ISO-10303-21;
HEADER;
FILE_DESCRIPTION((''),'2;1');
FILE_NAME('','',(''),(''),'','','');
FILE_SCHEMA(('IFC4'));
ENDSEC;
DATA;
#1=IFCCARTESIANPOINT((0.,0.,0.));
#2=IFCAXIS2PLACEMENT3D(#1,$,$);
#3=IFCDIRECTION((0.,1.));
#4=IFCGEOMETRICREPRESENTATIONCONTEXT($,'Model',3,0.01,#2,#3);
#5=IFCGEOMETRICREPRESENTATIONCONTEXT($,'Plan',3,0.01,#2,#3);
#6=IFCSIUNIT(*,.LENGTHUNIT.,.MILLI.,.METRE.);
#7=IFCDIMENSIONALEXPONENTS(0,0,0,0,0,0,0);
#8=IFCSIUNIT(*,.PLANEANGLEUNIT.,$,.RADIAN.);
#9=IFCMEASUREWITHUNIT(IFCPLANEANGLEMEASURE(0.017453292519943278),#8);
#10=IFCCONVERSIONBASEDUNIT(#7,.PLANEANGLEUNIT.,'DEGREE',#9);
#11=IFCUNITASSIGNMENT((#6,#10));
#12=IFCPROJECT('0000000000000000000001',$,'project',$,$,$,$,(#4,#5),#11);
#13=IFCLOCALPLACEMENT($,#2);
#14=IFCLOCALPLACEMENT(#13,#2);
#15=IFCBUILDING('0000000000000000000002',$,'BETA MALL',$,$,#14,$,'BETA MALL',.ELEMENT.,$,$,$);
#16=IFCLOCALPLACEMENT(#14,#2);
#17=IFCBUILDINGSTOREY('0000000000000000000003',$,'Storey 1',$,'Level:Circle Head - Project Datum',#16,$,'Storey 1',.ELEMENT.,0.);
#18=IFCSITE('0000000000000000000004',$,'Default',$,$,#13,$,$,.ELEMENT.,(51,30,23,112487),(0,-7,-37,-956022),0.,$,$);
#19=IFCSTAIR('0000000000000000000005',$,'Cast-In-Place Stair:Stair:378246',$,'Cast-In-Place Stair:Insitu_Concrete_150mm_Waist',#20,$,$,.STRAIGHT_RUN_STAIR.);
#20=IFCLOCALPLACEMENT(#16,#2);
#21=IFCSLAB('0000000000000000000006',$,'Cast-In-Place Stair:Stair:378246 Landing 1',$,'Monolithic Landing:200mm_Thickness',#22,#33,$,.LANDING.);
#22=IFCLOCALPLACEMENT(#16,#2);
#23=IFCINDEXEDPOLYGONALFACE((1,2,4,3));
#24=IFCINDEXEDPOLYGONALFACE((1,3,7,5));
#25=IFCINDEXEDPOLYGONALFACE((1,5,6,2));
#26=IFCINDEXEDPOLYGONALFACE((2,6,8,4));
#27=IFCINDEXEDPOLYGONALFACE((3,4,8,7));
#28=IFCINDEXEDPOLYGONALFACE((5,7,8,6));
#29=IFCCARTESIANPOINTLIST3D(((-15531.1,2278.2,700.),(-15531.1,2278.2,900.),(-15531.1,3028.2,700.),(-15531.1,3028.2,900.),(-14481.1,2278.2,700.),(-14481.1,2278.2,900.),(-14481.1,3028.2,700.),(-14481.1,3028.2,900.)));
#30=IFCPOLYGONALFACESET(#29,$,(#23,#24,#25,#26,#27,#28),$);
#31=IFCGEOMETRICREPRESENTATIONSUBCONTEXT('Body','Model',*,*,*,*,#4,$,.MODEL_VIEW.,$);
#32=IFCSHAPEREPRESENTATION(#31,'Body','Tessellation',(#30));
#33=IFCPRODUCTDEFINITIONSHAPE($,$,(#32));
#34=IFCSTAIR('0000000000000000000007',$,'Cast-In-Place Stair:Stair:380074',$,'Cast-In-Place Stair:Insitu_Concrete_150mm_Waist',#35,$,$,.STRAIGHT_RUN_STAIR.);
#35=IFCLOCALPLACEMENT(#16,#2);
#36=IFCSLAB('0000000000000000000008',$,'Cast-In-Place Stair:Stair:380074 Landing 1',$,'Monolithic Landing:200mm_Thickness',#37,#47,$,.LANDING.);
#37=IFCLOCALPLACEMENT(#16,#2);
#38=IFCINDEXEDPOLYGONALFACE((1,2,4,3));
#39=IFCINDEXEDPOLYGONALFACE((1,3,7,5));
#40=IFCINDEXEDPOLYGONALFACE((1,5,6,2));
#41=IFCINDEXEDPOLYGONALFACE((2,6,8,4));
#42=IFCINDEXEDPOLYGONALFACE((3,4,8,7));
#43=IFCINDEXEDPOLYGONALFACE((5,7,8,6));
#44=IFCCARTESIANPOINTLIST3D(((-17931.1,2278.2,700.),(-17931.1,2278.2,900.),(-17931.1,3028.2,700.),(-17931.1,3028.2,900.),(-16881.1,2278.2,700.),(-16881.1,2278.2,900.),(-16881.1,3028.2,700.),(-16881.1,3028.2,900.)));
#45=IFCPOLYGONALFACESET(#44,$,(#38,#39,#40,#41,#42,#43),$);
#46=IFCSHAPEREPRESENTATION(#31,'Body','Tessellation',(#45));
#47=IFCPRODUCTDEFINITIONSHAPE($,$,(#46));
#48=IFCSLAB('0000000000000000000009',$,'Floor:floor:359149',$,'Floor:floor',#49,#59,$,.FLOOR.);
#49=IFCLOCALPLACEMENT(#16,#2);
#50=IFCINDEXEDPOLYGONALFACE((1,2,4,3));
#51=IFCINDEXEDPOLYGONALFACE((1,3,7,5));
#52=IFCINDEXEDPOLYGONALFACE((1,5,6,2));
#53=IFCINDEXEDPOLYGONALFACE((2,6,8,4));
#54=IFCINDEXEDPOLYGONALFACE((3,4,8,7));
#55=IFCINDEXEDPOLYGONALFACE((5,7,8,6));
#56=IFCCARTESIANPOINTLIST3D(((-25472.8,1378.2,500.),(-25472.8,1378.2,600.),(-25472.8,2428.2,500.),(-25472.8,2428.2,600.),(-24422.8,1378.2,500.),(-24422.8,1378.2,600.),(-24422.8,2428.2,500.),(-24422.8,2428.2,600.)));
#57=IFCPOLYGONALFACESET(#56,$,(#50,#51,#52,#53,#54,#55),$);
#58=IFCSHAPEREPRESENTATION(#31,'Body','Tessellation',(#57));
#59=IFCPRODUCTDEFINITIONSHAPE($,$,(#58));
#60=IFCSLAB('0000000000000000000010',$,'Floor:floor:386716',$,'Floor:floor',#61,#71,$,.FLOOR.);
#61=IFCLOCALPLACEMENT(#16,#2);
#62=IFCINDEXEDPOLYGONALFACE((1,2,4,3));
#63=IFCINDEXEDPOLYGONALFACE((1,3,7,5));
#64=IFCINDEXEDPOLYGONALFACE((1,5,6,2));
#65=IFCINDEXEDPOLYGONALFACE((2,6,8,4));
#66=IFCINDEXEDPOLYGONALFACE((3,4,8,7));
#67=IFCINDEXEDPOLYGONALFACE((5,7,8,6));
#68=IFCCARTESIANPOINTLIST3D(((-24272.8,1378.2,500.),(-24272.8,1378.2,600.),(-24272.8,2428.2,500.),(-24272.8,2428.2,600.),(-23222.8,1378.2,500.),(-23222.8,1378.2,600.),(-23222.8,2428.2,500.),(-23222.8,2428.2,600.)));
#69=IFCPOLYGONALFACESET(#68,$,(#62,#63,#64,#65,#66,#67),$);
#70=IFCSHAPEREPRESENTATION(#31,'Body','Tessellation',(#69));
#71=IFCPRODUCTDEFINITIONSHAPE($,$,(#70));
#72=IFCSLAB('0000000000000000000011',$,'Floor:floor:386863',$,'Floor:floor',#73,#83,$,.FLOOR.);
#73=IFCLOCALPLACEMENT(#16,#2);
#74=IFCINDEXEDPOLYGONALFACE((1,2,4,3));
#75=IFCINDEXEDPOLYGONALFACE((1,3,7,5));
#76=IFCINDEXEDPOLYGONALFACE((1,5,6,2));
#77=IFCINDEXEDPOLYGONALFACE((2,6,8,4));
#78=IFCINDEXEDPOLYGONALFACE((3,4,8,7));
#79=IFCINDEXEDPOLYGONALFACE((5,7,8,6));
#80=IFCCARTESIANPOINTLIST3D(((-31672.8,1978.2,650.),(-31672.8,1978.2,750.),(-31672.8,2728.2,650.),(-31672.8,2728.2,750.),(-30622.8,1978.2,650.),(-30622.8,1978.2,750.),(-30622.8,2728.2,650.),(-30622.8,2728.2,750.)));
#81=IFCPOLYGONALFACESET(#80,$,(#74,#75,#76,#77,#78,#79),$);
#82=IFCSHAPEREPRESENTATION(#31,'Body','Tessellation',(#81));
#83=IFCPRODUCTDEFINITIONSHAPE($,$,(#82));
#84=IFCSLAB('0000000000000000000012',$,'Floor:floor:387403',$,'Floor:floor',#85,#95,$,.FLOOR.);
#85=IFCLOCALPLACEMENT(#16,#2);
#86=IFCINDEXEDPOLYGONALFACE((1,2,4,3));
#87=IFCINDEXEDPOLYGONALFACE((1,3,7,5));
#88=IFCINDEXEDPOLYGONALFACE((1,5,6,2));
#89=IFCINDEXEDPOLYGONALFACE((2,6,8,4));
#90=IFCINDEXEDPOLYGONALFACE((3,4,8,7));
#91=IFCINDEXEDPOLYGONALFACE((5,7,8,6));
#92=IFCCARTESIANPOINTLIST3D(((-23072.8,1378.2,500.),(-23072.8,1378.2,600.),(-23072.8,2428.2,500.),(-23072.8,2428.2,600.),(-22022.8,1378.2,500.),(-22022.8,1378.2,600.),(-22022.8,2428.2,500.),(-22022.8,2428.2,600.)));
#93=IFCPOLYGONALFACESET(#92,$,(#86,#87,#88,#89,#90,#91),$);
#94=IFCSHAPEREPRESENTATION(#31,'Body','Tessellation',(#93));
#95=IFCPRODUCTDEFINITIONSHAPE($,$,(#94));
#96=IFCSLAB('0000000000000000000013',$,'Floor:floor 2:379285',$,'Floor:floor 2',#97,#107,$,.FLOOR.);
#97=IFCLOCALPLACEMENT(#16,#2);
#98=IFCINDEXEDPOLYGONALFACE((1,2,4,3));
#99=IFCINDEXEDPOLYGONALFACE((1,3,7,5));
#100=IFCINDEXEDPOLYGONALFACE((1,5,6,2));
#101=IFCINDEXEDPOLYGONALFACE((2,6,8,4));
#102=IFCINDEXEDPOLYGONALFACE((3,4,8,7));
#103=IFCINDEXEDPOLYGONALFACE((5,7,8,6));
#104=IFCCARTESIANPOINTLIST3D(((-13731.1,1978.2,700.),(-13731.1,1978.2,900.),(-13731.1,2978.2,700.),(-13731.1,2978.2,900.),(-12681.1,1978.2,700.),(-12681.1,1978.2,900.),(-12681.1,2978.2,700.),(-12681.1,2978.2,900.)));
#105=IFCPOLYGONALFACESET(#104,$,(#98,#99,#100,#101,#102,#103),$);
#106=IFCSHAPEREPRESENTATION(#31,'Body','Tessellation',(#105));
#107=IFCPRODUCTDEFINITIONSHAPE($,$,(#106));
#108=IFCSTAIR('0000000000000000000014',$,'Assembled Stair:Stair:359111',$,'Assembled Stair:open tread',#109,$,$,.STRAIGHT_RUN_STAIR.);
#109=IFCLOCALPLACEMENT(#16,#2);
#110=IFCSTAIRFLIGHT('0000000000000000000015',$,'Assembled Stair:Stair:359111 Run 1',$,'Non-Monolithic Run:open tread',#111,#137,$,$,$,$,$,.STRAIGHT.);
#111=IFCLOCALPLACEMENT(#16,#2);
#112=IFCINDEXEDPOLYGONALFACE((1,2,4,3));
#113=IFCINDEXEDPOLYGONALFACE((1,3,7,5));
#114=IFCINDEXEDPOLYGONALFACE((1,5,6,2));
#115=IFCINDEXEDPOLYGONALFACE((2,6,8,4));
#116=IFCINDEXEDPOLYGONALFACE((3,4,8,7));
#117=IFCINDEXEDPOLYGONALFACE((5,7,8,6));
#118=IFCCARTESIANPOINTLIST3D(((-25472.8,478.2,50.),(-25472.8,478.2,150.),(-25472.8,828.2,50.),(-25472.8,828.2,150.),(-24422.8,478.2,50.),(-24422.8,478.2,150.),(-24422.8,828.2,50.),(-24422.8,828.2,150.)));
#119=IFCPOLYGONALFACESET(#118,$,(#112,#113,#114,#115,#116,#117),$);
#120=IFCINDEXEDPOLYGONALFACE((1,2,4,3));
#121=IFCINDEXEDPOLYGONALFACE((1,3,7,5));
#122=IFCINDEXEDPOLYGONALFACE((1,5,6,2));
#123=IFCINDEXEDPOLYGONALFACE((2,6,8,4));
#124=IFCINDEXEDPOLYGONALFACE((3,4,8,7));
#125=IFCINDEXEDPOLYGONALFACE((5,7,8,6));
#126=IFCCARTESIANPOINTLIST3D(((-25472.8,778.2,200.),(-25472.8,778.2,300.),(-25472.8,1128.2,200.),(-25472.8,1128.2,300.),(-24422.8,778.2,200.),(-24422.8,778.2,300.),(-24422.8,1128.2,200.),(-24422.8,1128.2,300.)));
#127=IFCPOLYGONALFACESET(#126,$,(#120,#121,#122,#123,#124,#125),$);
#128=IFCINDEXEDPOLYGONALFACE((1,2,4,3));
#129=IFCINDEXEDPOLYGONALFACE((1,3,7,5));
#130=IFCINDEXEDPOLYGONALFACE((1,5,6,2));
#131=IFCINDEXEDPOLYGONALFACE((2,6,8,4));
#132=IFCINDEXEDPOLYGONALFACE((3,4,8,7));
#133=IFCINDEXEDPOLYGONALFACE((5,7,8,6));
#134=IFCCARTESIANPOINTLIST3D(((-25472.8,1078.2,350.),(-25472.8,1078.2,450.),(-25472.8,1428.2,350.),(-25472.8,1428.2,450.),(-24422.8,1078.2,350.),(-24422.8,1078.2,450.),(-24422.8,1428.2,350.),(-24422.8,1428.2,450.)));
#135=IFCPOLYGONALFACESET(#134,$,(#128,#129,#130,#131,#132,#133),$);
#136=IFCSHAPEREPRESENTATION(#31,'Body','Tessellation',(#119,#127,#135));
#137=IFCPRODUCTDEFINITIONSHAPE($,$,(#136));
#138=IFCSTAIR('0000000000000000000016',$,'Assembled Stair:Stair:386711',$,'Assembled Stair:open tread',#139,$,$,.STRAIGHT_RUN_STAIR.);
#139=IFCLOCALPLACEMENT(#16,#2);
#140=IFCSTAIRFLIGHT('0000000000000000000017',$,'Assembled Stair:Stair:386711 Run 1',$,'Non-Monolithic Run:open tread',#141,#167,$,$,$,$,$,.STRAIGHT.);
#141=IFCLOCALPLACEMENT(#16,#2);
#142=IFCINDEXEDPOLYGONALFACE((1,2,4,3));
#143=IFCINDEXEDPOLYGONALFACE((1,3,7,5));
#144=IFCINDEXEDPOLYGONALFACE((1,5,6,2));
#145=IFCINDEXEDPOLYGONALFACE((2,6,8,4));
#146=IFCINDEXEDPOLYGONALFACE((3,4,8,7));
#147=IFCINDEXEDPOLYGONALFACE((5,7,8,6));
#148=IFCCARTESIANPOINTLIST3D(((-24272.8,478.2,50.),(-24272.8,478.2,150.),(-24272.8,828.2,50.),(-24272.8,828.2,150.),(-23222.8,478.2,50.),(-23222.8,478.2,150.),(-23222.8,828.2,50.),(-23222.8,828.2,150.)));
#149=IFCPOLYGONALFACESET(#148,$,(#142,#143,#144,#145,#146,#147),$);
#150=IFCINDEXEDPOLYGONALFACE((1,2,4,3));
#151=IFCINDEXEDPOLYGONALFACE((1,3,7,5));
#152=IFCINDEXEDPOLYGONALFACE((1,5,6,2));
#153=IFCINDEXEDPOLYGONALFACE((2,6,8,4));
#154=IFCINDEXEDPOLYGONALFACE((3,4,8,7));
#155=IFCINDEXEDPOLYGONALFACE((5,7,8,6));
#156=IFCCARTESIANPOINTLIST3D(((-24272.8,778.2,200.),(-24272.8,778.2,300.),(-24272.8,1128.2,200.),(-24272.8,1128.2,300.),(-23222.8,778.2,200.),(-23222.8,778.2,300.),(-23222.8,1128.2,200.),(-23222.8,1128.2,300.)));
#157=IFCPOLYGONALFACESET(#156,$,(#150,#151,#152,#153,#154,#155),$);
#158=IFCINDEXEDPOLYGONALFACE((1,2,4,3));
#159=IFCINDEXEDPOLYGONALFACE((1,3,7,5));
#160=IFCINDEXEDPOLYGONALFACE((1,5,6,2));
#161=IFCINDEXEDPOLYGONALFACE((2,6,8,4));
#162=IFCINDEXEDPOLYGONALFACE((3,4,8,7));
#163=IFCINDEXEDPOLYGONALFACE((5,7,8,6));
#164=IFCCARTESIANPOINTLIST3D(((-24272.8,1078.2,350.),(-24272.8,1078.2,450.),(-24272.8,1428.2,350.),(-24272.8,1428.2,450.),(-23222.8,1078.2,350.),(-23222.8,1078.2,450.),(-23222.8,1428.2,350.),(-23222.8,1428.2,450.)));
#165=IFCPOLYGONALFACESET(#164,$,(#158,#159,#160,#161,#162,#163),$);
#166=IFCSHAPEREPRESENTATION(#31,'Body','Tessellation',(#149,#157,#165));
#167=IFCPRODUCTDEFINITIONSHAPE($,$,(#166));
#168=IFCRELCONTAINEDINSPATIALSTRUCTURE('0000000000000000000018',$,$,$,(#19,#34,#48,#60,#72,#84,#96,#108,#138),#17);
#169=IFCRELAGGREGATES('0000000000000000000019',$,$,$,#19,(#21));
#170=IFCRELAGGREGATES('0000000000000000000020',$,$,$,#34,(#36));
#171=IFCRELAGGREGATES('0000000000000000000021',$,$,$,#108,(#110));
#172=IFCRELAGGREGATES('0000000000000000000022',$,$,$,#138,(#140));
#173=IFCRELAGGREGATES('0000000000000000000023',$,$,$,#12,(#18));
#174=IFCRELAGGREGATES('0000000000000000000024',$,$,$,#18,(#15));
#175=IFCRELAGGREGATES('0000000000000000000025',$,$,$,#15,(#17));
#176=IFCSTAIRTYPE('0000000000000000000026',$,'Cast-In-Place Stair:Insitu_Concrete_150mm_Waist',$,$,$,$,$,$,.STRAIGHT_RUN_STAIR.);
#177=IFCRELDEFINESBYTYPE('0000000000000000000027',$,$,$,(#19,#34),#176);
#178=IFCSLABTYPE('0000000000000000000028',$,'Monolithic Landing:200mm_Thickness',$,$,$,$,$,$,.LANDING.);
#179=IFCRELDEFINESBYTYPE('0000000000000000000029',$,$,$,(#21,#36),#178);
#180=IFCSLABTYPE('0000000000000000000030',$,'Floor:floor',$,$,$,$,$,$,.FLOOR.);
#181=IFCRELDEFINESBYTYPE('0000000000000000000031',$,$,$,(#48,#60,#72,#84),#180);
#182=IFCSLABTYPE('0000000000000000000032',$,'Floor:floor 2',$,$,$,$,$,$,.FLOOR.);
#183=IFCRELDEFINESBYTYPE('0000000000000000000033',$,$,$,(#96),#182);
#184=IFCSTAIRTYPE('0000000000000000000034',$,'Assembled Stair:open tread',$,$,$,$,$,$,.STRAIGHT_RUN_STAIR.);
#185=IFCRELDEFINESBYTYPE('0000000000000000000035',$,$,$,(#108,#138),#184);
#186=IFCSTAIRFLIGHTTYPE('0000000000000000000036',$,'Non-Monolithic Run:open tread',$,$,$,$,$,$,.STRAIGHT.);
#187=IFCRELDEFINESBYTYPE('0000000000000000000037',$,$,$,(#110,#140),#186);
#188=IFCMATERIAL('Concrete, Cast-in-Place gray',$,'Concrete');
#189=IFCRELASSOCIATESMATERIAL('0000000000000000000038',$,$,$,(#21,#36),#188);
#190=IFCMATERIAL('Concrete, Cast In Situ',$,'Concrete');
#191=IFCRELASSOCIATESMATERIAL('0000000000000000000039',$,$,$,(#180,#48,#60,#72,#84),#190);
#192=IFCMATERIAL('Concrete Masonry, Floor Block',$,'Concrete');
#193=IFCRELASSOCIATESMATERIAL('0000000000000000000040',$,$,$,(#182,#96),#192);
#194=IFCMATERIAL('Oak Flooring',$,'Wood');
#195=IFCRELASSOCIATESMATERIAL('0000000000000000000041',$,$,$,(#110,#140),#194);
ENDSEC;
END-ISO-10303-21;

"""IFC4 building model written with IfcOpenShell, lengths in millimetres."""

from ifc_helpers import new_model, entity, si_unit, converted_unit, direction, frame, origin, place, context, subcontext, project, spatial, indexed_curve, outline, extrude, material, type_object, element, aggregate, save


model = new_model("IFC4")

# Units and contexts
model_context = context("Model", 3, precision=0.01, world=origin(), true_north=direction((0.0, 1.0)))
plan_context = context("Plan", 3, precision=0.01, world=origin(), true_north=direction((0.0, 1.0)))
body_context = subcontext(model_context, "Body", "Model", "MODEL_VIEW")
ifc_project = project(units=[si_unit("LENGTHUNIT", "METRE", prefix="MILLI"), converted_unit("PLANEANGLEUNIT", "DEGREE", entity("IfcPlaneAngleMeasure", 0.017453292519943278), si_unit("PLANEANGLEUNIT", "RADIAN"), dimensions=[0, 0, 0, 0, 0, 0, 0])], contexts=[model_context, plan_context])

# Site, building, storey
site_placement = place(None, origin())
site = spatial("IfcSite", under=ifc_project, at=site_placement, Name="Default", CompositionType="ELEMENT", RefLatitude=(51, 30, 23, 112487), RefLongitude=(0, -7, -37, -956022), RefElevation=0.0)
building_placement = place(site_placement, origin())
building = spatial("IfcBuilding", under=site, at=building_placement, Name="BETA MALL", LongName="BETA MALL", CompositionType="ELEMENT")
storey_placement = place(building_placement, origin())
storey = spatial("IfcBuildingStorey", under=building, at=storey_placement, Name="Storey 1", ObjectType="Level:Circle Head - Project Datum", LongName="Storey 1", CompositionType="ELEMENT", Elevation=0.0)

# Stairs, slabs
stair_type_1 = type_object("IfcStairType", Name="Cast-In-Place Stair:Insitu_Concrete_150mm_Waist", PredefinedType="STRAIGHT_RUN_STAIR")
ifc_material_1 = material(Name="Concrete, Cast-in-Place gray", Category="Concrete")
slab_type_1 = type_object("IfcSlabType", Name="Monolithic Landing:200mm_Thickness", PredefinedType="LANDING")
stair_1_placement = place(storey_placement, origin())
stair_1 = element("IfcStair", 1, at=stair_1_placement, inside=storey, type_object=stair_type_1, Name="Cast-In-Place Stair:Stair:378246", ObjectType="Cast-In-Place Stair:Insitu_Concrete_150mm_Waist", PredefinedType="STRAIGHT_RUN_STAIR")
slab_1_placement = place(stair_1_placement, origin())
slab_1 = element("IfcSlab", 2, at=slab_1_placement, type_object=slab_type_1, material=ifc_material_1, Name="Cast-In-Place Stair:Stair:378246 Landing 1", ObjectType="Monolithic Landing:200mm_Thickness", PredefinedType="LANDING", context=body_context, shape_type="SweptSolid", body=[
    extrude(outline(indexed_curve([(-375.0, -525.0), (375.0, -525.0), (375.0, 525.0), (-375.0, 525.0), (-375.0, -525.0)], self_intersect=False)), frame((-15006.1, 2653.2, 700.0), z_axis=(0.0, 0.0, 1.0), x_axis=(0.0, 1.0, 0.0)), (0.0, 0.0, 1.0), 200.0),
])
aggregate(stair_1, [slab_1])
stair_2_placement = place(storey_placement, origin())
stair_2 = element("IfcStair", 3, at=stair_2_placement, inside=storey, type_object=stair_type_1, Name="Cast-In-Place Stair:Stair:380074", ObjectType="Cast-In-Place Stair:Insitu_Concrete_150mm_Waist", PredefinedType="STRAIGHT_RUN_STAIR")
slab_2_placement = place(stair_2_placement, origin())
slab_2 = element("IfcSlab", 4, at=slab_2_placement, type_object=slab_type_1, material=ifc_material_1, Name="Cast-In-Place Stair:Stair:380074 Landing 1", ObjectType="Monolithic Landing:200mm_Thickness", PredefinedType="LANDING", context=body_context, shape_type="SweptSolid", body=[
    extrude(outline(indexed_curve([(-375.0, -525.0), (375.0, -525.0), (375.0, 525.0), (-375.0, 525.0), (-375.0, -525.0)], self_intersect=False)), frame((-17406.1, 2653.2, 700.0), z_axis=(0.0, 0.0, 1.0), x_axis=(0.0, 1.0, 0.0)), (0.0, 0.0, 1.0), 200.0),
])
aggregate(stair_2, [slab_2])

# Slabs
ifc_material_2 = material(Name="Concrete, Cast In Situ", Category="Concrete")
slab_type_2 = type_object("IfcSlabType", Name="Floor:floor", PredefinedType="FLOOR", material=ifc_material_2)
slab_3_placement = place(storey_placement, origin())
element("IfcSlab", 5, at=slab_3_placement, inside=storey, type_object=slab_type_2, material=ifc_material_2, Name="Floor:floor:359149", ObjectType="Floor:floor", PredefinedType="FLOOR", context=body_context, shape_type="SweptSolid", body=[
    extrude(outline(indexed_curve([(-525.0, -525.0), (525.0, -525.0), (525.0, 525.0), (-525.0, 525.0), (-525.0, -525.0)], self_intersect=False)), frame((-24947.8, 1903.2, 600.0), z_axis=(0.0, 0.0, -1.0), x_axis=(0.0, 1.0, 0.0)), (0.0, 0.0, 1.0), 100.0),
])
slab_4_placement = place(storey_placement, origin())
element("IfcSlab", 6, at=slab_4_placement, inside=storey, type_object=slab_type_2, material=ifc_material_2, Name="Floor:floor:386716", ObjectType="Floor:floor", PredefinedType="FLOOR", context=body_context, shape_type="SweptSolid", body=[
    extrude(outline(indexed_curve([(-525.0, -525.0), (525.0, -525.0), (525.0, 525.0), (-525.0, 525.0), (-525.0, -525.0)], self_intersect=False)), frame((-23747.8, 1903.2, 600.0), z_axis=(0.0, 0.0, -1.0), x_axis=(0.0, 1.0, 0.0)), (0.0, 0.0, 1.0), 100.0),
])
slab_5_placement = place(storey_placement, origin())
element("IfcSlab", 7, at=slab_5_placement, inside=storey, type_object=slab_type_2, material=ifc_material_2, Name="Floor:floor:386863", ObjectType="Floor:floor", PredefinedType="FLOOR", context=body_context, shape_type="SweptSolid", body=[
    extrude(outline(indexed_curve([(-375.0, -525.0), (375.0, -525.0), (375.0, 525.0), (-375.0, 525.0), (-375.0, -525.0)], self_intersect=False)), frame((-31147.8, 2353.2, 750.0), z_axis=(0.0, 0.0, -1.0), x_axis=(0.0, 1.0, 0.0)), (0.0, 0.0, 1.0), 100.0),
])
slab_6_placement = place(storey_placement, origin())
element("IfcSlab", 8, at=slab_6_placement, inside=storey, type_object=slab_type_2, material=ifc_material_2, Name="Floor:floor:387403", ObjectType="Floor:floor", PredefinedType="FLOOR", context=body_context, shape_type="SweptSolid", body=[
    extrude(outline(indexed_curve([(-525.0, -525.0), (525.0, -525.0), (525.0, 525.0), (-525.0, 525.0), (-525.0, -525.0)], self_intersect=False)), frame((-22547.8, 1903.2, 600.0), z_axis=(0.0, 0.0, -1.0), x_axis=(0.0, 1.0, 0.0)), (0.0, 0.0, 1.0), 100.0),
])
ifc_material_3 = material(Name="Concrete Masonry, Floor Block", Category="Concrete")
slab_type_3 = type_object("IfcSlabType", Name="Floor:floor 2", PredefinedType="FLOOR", material=ifc_material_3)
slab_7_placement = place(storey_placement, origin())
element("IfcSlab", 9, at=slab_7_placement, inside=storey, type_object=slab_type_3, material=ifc_material_3, Name="Floor:floor 2:379285", ObjectType="Floor:floor 2", PredefinedType="FLOOR", context=body_context, shape_type="SweptSolid", body=[
    extrude(outline(indexed_curve([(-500.0, -525.0), (500.0, -525.0), (500.0, 525.0), (-500.0, 525.0), (-500.0, -525.0)], self_intersect=False)), frame((-13206.1, 2478.2, 900.0), z_axis=(0.0, 0.0, -1.0), x_axis=(0.0, 1.0, 0.0)), (0.0, 0.0, 1.0), 200.0),
])

# Stairs, stair flights
stair_type_2 = type_object("IfcStairType", Name="Assembled Stair:open tread", PredefinedType="STRAIGHT_RUN_STAIR")
stair_3_placement = place(storey_placement, origin())
stair_3 = element("IfcStair", 10, at=stair_3_placement, inside=storey, type_object=stair_type_2, Name="Assembled Stair:Stair:359111", ObjectType="Assembled Stair:open tread", PredefinedType="STRAIGHT_RUN_STAIR")
ifc_material_4 = material(Name="Oak Flooring", Category="Wood")
stair_flight_type_1 = type_object("IfcStairFlightType", Name="Non-Monolithic Run:open tread", PredefinedType="STRAIGHT")
stair_flight_1_placement = place(stair_3_placement, origin())
stair_flight_1 = element("IfcStairFlight", 11, at=stair_flight_1_placement, type_object=stair_flight_type_1, material=ifc_material_4, Name="Assembled Stair:Stair:359111 Run 1", ObjectType="Non-Monolithic Run:open tread", PredefinedType="STRAIGHT", context=body_context, shape_type="SweptSolid", body=[
    extrude(outline(indexed_curve([(-525.0, -175.0), (525.0, -175.0), (525.0, 175.0), (-525.0, 175.0), (-525.0, -175.0)], self_intersect=False)), frame((-24947.8, 653.2, 50.0), z_axis=(0.0, 0.0, 1.0), x_axis=(-1.0, 0.0, 0.0)), (0.0, 0.0, 1.0), 100.0),
    extrude(outline(indexed_curve([(-525.0, -175.0), (525.0, -175.0), (525.0, 175.0), (-525.0, 175.0), (-525.0, -175.0)], self_intersect=False)), frame((-24947.8, 953.2, 200.0), z_axis=(0.0, 0.0, 1.0), x_axis=(-1.0, 0.0, 0.0)), (0.0, 0.0, 1.0), 100.0),
    extrude(outline(indexed_curve([(-525.0, -175.0), (525.0, -175.0), (525.0, 175.0), (-525.0, 175.0), (-525.0, -175.0)], self_intersect=False)), frame((-24947.8, 1253.2, 350.0), z_axis=(0.0, 0.0, 1.0), x_axis=(-1.0, 0.0, 0.0)), (0.0, 0.0, 1.0), 100.0),
])
aggregate(stair_3, [stair_flight_1])
stair_4_placement = place(storey_placement, origin())
stair_4 = element("IfcStair", 12, at=stair_4_placement, inside=storey, type_object=stair_type_2, Name="Assembled Stair:Stair:386711", ObjectType="Assembled Stair:open tread", PredefinedType="STRAIGHT_RUN_STAIR")
stair_flight_2_placement = place(stair_4_placement, origin())
stair_flight_2 = element("IfcStairFlight", 13, at=stair_flight_2_placement, type_object=stair_flight_type_1, material=ifc_material_4, Name="Assembled Stair:Stair:386711 Run 1", ObjectType="Non-Monolithic Run:open tread", PredefinedType="STRAIGHT", context=body_context, shape_type="SweptSolid", body=[
    extrude(outline(indexed_curve([(-525.0, -175.0), (525.0, -175.0), (525.0, 175.0), (-525.0, 175.0), (-525.0, -175.0)], self_intersect=False)), frame((-23747.8, 653.2, 50.0), z_axis=(0.0, 0.0, 1.0), x_axis=(-1.0, 0.0, 0.0)), (0.0, 0.0, 1.0), 100.0),
    extrude(outline(indexed_curve([(-525.0, -175.0), (525.0, -175.0), (525.0, 175.0), (-525.0, 175.0), (-525.0, -175.0)], self_intersect=False)), frame((-23747.8, 953.2, 200.0), z_axis=(0.0, 0.0, 1.0), x_axis=(-1.0, 0.0, 0.0)), (0.0, 0.0, 1.0), 100.0),
    extrude(outline(indexed_curve([(-525.0, -175.0), (525.0, -175.0), (525.0, 175.0), (-525.0, 175.0), (-525.0, -175.0)], self_intersect=False)), frame((-23747.8, 1253.2, 350.0), z_axis=(0.0, 0.0, 1.0), x_axis=(-1.0, 0.0, 0.0)), (0.0, 0.0, 1.0), 100.0),
])
aggregate(stair_4, [stair_flight_2])

save(model, "model.ifc")
